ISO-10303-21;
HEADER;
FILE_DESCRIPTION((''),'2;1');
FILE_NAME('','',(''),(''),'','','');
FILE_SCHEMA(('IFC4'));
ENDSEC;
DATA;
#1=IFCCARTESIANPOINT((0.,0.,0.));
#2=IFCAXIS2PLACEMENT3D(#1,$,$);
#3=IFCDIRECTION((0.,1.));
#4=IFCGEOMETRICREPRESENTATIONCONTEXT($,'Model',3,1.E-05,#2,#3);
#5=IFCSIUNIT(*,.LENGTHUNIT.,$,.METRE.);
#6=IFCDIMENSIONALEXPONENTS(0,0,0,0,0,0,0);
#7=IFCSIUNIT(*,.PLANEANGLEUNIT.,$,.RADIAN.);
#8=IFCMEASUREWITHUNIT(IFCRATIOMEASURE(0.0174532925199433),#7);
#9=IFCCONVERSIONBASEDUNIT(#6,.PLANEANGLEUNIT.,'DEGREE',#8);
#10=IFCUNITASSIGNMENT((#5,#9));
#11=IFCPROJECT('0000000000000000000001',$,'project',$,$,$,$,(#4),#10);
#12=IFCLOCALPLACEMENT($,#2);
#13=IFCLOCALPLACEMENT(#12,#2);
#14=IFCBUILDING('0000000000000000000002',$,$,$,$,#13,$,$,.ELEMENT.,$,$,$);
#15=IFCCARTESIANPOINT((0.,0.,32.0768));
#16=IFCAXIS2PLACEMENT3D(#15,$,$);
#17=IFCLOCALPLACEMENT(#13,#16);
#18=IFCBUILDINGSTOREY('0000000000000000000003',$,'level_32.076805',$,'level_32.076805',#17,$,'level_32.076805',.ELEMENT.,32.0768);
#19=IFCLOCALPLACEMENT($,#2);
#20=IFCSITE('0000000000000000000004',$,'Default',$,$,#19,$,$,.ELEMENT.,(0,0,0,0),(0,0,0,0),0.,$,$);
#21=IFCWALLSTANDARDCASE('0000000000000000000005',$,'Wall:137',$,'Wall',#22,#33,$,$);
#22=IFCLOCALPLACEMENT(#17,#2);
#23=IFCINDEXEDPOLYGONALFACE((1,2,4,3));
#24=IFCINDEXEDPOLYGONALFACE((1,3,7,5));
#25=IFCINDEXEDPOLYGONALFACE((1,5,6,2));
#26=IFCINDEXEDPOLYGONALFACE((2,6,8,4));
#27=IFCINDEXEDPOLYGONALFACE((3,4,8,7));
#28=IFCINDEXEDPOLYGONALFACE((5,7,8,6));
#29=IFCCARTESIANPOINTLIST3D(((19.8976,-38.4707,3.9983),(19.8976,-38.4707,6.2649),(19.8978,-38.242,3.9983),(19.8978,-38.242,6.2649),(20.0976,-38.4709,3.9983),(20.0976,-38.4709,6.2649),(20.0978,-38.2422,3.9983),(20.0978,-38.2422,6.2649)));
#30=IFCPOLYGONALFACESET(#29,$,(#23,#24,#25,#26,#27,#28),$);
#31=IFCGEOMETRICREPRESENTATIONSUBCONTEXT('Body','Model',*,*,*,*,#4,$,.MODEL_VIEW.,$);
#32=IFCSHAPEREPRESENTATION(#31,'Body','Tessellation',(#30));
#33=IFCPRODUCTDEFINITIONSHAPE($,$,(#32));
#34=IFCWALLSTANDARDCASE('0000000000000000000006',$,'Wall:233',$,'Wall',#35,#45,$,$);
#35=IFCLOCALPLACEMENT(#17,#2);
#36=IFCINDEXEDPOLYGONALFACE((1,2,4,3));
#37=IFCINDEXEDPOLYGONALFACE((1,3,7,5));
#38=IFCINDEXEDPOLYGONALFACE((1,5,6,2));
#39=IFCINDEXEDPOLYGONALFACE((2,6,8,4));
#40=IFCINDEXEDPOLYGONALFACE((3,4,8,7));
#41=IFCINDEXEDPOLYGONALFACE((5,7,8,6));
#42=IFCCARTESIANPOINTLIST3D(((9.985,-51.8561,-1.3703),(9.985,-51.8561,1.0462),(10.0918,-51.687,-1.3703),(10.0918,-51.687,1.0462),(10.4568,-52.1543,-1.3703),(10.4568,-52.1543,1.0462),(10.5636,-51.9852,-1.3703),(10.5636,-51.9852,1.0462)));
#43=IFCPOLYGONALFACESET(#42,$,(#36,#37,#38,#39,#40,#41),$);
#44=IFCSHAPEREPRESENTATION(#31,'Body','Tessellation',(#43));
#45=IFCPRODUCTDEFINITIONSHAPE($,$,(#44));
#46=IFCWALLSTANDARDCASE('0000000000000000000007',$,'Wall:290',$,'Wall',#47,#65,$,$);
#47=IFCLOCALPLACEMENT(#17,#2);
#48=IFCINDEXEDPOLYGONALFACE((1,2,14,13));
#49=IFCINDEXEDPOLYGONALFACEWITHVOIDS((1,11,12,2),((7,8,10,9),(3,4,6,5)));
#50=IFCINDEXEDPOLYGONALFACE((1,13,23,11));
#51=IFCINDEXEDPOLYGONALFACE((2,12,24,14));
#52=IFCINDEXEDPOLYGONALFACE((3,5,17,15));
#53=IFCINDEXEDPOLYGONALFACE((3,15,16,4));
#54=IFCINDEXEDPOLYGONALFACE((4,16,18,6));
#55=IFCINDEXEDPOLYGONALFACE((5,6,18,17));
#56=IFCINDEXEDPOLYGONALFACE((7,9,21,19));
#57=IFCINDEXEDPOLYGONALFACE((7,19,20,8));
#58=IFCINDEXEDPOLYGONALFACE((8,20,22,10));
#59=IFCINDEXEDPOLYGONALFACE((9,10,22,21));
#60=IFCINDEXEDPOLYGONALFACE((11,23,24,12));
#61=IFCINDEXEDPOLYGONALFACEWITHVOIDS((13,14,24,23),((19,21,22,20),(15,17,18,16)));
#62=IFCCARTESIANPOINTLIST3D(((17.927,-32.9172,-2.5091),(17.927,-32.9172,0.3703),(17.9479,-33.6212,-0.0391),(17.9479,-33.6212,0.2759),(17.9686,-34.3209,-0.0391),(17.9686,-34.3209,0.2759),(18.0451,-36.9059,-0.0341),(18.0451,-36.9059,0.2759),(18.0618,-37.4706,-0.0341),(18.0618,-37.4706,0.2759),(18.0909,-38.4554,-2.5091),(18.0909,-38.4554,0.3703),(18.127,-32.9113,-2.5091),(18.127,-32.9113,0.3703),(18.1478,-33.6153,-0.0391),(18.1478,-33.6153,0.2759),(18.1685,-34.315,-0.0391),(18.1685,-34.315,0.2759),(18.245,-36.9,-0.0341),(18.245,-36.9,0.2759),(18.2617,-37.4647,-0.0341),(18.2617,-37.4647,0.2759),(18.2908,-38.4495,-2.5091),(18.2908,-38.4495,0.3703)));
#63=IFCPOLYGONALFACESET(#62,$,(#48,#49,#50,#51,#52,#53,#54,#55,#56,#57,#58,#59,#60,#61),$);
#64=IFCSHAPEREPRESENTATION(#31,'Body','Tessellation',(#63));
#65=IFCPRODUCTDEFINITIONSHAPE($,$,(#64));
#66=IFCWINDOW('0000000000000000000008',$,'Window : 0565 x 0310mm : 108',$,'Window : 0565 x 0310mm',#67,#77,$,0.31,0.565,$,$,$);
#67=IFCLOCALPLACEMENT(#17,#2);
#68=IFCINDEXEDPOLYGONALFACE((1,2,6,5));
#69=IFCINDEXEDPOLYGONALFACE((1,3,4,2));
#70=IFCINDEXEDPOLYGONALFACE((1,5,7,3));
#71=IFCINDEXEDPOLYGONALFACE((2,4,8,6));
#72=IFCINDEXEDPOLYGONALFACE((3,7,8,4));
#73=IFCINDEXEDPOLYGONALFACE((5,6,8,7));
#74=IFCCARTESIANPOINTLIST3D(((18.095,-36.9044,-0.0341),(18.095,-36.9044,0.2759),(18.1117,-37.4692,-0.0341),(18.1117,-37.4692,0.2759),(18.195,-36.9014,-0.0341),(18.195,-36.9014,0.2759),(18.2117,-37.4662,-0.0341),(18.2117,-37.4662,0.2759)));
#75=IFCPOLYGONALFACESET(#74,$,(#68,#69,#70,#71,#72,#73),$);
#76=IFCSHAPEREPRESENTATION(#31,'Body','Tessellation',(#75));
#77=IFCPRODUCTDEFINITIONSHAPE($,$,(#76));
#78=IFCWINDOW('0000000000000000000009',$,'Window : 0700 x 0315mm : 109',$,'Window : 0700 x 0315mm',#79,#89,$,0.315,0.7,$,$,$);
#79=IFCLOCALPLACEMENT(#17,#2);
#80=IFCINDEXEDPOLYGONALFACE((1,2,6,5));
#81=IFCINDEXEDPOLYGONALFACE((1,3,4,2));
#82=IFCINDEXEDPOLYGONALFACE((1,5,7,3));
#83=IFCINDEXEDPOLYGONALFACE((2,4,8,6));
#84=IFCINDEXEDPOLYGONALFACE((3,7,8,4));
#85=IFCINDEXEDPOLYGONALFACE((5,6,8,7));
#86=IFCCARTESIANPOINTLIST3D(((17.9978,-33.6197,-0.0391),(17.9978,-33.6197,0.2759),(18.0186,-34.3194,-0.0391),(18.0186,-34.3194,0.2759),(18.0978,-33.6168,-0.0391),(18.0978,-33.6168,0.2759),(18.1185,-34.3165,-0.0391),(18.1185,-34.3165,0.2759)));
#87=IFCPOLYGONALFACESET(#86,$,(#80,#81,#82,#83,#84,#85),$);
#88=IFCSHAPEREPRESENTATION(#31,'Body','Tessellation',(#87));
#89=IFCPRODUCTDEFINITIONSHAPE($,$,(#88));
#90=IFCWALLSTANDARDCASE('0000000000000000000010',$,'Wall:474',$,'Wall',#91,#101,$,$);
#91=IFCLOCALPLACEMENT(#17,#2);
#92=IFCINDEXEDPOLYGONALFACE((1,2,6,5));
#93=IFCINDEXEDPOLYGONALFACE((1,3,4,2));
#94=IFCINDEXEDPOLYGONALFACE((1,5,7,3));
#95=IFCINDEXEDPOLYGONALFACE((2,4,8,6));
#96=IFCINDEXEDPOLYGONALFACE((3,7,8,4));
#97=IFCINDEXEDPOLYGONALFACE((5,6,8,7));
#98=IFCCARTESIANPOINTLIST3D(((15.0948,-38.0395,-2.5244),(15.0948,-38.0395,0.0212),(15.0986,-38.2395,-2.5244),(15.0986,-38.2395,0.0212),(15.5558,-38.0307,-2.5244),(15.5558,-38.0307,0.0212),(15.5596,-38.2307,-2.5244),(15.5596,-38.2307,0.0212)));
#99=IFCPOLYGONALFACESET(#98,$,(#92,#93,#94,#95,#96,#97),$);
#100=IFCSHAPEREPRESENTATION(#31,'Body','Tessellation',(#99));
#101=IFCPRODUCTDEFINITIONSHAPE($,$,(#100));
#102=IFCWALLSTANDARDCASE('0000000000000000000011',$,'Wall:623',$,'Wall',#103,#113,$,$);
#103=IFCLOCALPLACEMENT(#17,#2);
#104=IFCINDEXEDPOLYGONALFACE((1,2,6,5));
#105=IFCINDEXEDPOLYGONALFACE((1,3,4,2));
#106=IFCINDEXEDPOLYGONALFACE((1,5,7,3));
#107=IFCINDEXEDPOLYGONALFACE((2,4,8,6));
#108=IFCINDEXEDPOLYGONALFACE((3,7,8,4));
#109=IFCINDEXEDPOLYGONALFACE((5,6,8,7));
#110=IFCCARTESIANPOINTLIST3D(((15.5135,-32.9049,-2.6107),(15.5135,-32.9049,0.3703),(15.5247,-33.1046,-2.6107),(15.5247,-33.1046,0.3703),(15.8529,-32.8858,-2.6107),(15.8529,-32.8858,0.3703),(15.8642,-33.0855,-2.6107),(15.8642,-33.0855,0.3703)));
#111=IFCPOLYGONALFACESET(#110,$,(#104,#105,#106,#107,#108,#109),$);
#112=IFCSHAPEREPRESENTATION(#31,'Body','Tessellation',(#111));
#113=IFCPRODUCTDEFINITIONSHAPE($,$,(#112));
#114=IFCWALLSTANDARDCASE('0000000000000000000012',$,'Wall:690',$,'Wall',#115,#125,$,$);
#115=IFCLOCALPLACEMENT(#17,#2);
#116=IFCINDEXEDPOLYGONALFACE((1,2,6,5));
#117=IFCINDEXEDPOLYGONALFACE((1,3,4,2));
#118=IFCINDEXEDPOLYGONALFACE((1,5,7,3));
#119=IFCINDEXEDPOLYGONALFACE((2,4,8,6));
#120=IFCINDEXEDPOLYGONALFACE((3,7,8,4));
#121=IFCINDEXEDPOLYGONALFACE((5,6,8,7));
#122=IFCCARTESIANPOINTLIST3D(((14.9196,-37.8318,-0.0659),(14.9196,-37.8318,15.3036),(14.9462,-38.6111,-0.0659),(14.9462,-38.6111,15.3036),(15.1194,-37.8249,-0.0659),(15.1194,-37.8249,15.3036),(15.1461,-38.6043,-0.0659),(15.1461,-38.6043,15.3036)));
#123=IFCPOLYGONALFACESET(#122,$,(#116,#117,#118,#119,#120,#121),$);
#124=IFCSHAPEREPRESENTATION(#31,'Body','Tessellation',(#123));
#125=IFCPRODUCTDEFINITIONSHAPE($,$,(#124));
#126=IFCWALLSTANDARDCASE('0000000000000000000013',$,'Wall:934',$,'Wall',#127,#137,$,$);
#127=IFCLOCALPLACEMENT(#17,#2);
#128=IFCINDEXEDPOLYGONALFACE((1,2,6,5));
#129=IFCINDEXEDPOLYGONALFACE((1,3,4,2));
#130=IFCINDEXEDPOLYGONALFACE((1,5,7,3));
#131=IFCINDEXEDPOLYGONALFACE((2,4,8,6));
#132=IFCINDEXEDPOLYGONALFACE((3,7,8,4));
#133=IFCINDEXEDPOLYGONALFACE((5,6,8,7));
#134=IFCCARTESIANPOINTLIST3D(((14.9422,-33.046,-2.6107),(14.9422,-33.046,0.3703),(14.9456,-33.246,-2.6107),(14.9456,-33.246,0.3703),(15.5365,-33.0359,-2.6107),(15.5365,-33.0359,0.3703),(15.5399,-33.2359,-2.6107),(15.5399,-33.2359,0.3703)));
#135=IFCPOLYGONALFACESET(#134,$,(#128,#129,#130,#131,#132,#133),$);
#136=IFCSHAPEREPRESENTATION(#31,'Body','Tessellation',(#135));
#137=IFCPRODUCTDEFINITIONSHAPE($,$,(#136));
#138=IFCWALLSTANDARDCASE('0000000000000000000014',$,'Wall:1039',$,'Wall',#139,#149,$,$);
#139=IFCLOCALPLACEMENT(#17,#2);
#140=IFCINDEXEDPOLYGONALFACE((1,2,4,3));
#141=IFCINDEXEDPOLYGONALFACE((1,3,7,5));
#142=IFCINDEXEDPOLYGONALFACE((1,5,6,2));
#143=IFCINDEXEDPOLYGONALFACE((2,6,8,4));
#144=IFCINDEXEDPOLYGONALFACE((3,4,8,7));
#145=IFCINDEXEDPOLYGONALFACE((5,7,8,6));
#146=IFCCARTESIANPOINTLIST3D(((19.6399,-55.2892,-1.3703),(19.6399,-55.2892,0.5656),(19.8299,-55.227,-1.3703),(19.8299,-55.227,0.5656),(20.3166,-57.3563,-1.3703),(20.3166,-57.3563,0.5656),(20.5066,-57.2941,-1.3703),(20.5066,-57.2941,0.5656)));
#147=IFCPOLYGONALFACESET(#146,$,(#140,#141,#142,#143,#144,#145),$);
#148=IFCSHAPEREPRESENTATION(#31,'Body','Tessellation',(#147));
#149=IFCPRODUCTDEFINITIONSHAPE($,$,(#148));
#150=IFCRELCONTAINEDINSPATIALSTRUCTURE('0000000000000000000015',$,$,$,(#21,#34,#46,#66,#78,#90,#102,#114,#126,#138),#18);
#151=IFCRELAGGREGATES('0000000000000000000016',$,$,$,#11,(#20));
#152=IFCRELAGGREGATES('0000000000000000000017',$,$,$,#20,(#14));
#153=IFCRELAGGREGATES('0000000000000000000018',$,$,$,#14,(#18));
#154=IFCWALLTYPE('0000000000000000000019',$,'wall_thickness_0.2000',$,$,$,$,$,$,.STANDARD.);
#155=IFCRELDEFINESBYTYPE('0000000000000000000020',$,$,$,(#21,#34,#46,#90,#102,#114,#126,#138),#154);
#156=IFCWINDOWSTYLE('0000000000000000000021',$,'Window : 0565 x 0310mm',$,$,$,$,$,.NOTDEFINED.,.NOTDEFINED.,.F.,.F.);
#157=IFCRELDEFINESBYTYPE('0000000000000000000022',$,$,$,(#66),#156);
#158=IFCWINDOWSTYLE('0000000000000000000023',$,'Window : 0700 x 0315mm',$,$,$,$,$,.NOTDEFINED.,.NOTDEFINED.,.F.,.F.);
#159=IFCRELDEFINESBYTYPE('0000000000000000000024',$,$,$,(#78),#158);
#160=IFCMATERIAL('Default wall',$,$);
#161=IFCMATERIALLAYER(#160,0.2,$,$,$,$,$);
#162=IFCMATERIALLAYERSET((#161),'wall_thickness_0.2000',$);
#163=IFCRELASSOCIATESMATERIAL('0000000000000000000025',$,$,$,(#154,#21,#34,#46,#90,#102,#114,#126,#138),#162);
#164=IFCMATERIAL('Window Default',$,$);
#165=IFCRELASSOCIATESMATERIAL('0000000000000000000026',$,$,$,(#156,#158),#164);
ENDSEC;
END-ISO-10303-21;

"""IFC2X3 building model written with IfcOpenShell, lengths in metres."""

from ifc_helpers import new_model, entity, si_unit, converted_unit, direction, frame, frame_2d, origin, origin_2d_with_axis, place, context, subcontext, project, spatial, polyline, rectangle, outline, extrude, source, transform, mapped, material, layer, layer_set, layer_usage, type_object, type_shapes, element, fill, save


model = new_model("IFC2X3")

# Units and contexts
model_context = context("Model", 3, precision=1e-05, world=origin(), true_north=direction((0.0, 1.0)))
body_context = subcontext(model_context, "Body", "Model", "MODEL_VIEW")
ifc_project = project(units=[si_unit("LENGTHUNIT", "METRE"), converted_unit("PLANEANGLEUNIT", "DEGREE", entity("IfcRatioMeasure", 0.0174532925199433), si_unit("PLANEANGLEUNIT", "RADIAN"), dimensions=[0, 0, 0, 0, 0, 0, 0])], contexts=[model_context])

# Site, building, storey
site_placement = place(None, origin())
site = spatial("IfcSite", under=ifc_project, at=site_placement, Name="Default", CompositionType="ELEMENT", RefLatitude=(0, 0, 0, 0), RefLongitude=(0, 0, 0, 0), RefElevation=0.0)
placement_1 = place(None, origin())
building_placement = place(placement_1, origin())
building = spatial("IfcBuilding", under=site, at=building_placement, CompositionType="ELEMENT")
storey_placement = place(building_placement, frame((0.0, 0.0, 32.0768)))
storey = spatial("IfcBuildingStorey", under=building, at=storey_placement, Name="level_32.076805", ObjectType="level_32.076805", LongName="level_32.076805", CompositionType="ELEMENT", Elevation=32.0768)

# Walls
ifc_material_1 = material(Name="Default wall")
ifc_layer = layer(ifc_material_1, 0.2)
ifc_layer_set = layer_set([ifc_layer], Name="wall_thickness_0.2000")
ifc_layer_usage = layer_usage(ifc_layer_set, "AXIS2", "POSITIVE", -0.1)
wall_type = type_object("IfcWallType", Name="wall_thickness_0.2000", PredefinedType="STANDARD", material=ifc_layer_set)
placement_2 = place(building_placement, frame((0.0, 0.0, 36.0751)))
wall_1_placement = place(placement_2, frame((19.9976, -38.4708, 0.0), z_axis=(0.0, 0.0, 1.0), x_axis=(0.001093, 0.999999, 0.0)))
element("IfcWallStandardCase", 1, at=wall_1_placement, inside=storey, type_object=wall_type, material=ifc_layer_usage, Name="Wall:137", ObjectType="Wall", context=body_context, shape_type="SweptSolid", body=[
    extrude(outline(polyline([(0.2287, -0.1), (0.2287, 0.1), (0.0, 0.1), (0.0, -0.1), (0.2287, -0.1)])), origin(), (0.0, 0.0, 1.0), 2.2666),
])
placement_3 = place(building_placement, frame((0.0, 0.0, 30.7065)))
wall_2_placement = place(placement_3, frame((10.5102, -52.0698, 0.0), z_axis=(0.0, 0.0, 1.0), x_axis=(-0.84531, 0.534276, 0.0)))
element("IfcWallStandardCase", 2, at=wall_2_placement, inside=storey, type_object=wall_type, material=ifc_layer_usage, Name="Wall:233", ObjectType="Wall", context=body_context, shape_type="SweptSolid", body=[
    extrude(outline(polyline([(0.5581, -0.1), (0.5581, 0.1), (0.0, 0.1), (0.0, -0.1), (0.5581, -0.1)])), origin(), (0.0, 0.0, 1.0), 2.4165),
])

# Wall, openings, windows
placement_4 = place(building_placement, frame((0.0, 0.0, 29.5677)))
wall_3_placement = place(placement_4, frame((18.1909, -38.4525, 0.0), z_axis=(0.0, 0.0, 1.0), x_axis=(-0.029576, 0.999563, 0.0)))
wall_3 = element("IfcWallStandardCase", 3, at=wall_3_placement, inside=storey, type_object=wall_type, material=ifc_layer_usage, Name="Wall:290", ObjectType="Wall", context=body_context, shape_type="SweptSolid", body=[
    extrude(outline(polyline([(5.5406, -0.1), (5.5406, 0.1), (0.0, 0.1), (0.0, -0.1), (5.5406, -0.1)])), origin(), (0.0, 0.0, 1.0), 2.8794),
])
opening_1_placement = place(wall_3_placement, frame((0.9852, -0.1, 2.475)))
opening_1 = element("IfcOpeningElement", 4, at=opening_1_placement, cuts=wall_3, ObjectType="Opening", context=body_context, shape_type="SweptSolid", body=[
    extrude(rectangle(XDim=0.565, YDim=0.31, at=frame_2d((0.155, 0.2825), x_axis=(0.0, 1.0))), frame((0.0, 0.0, 0.0), z_axis=(0.0, 1.0, 0.0), x_axis=(0.0, 0.0, 1.0)), (0.0, 0.0, 1.0), 0.2),
])
opening_2_placement = place(wall_3_placement, frame((4.1363, -0.1, 2.47)))
opening_2 = element("IfcOpeningElement", 5, at=opening_2_placement, cuts=wall_3, ObjectType="Opening", context=body_context, shape_type="SweptSolid", body=[
    extrude(rectangle(XDim=0.7, YDim=0.315, at=frame_2d((0.1575, 0.35), x_axis=(0.0, 1.0))), frame((0.0, 0.0, 0.0), z_axis=(0.0, 1.0, 0.0), x_axis=(0.0, 0.0, 1.0)), (0.0, 0.0, 1.0), 0.2),
])
ifc_material_2 = material(Name="Window Default")
window_style_1 = type_object("IfcWindowStyle", Name="Window : 0565 x 0310mm", ConstructionType="NOTDEFINED", OperationType="NOTDEFINED", ParameterTakesPrecedence=False, Sizeable=False, material=ifc_material_2)
shared_shape_1 = source(origin(), body_context, "Body", "SweptSolid", [
    extrude(rectangle(XDim=0.1, YDim=0.565, at=origin_2d_with_axis()), frame((0.2825, 0.1, 0.0), z_axis=(0.0, 0.0, 1.0), x_axis=(0.0, 1.0, 0.0)), (0.0, 0.0, 1.0), 0.31),
])
type_shapes(window_style_1, [shared_shape_1])
window_1_placement = place(opening_1_placement, origin())
window_1 = element("IfcWindow", 6, at=window_1_placement, inside=storey, type_object=window_style_1, Name="Window : 0565 x 0310mm : 108", ObjectType="Window : 0565 x 0310mm", OverallHeight=0.31, OverallWidth=0.565, context=body_context, shape_type="MappedRepresentation", body=[
    mapped(shared_shape_1, transform((0.0, 0.0, 0.0), scale=1.0)),
])
fill(opening_1, window_1)
window_style_2 = type_object("IfcWindowStyle", Name="Window : 0700 x 0315mm", ConstructionType="NOTDEFINED", OperationType="NOTDEFINED", ParameterTakesPrecedence=False, Sizeable=False, material=ifc_material_2)
shared_shape_2 = source(origin(), body_context, "Body", "SweptSolid", [
    extrude(rectangle(XDim=0.1, YDim=0.7, at=origin_2d_with_axis()), frame((0.35, 0.1, 0.0), z_axis=(0.0, 0.0, 1.0), x_axis=(0.0, 1.0, 0.0)), (0.0, 0.0, 1.0), 0.315),
])
type_shapes(window_style_2, [shared_shape_2])
window_2_placement = place(opening_2_placement, origin())
window_2 = element("IfcWindow", 7, at=window_2_placement, inside=storey, type_object=window_style_2, Name="Window : 0700 x 0315mm : 109", ObjectType="Window : 0700 x 0315mm", OverallHeight=0.315, OverallWidth=0.7, context=body_context, shape_type="MappedRepresentation", body=[
    mapped(shared_shape_2, transform((0.0, 0.0, 0.0), scale=1.0)),
])
fill(opening_2, window_2)

# Walls
placement_5 = place(building_placement, frame((0.0, 0.0, 29.5524)))
wall_4_placement = place(placement_5, frame((15.5577, -38.1307, 0.0), z_axis=(0.0, 0.0, 1.0), x_axis=(-0.999819, -0.019046, 0.0)))
element("IfcWallStandardCase", 8, at=wall_4_placement, inside=storey, type_object=wall_type, material=ifc_layer_usage, Name="Wall:474", ObjectType="Wall", context=body_context, shape_type="SweptSolid", body=[
    extrude(outline(polyline([(0.4611, -0.1), (0.4611, 0.1), (0.0, 0.1), (0.0, -0.1), (0.4611, -0.1)])), origin(), (0.0, 0.0, 1.0), 2.5456),
])
placement_6 = place(building_placement, frame((0.0, 0.0, 29.4661)))
wall_5_placement = place(placement_6, frame((15.8585, -32.9856, 0.0), z_axis=(0.0, 0.0, 1.0), x_axis=(-0.998418, -0.056233, 0.0)))
element("IfcWallStandardCase", 9, at=wall_5_placement, inside=storey, type_object=wall_type, material=ifc_layer_usage, Name="Wall:623", ObjectType="Wall", context=body_context, shape_type="SweptSolid", body=[
    extrude(outline(polyline([(0.34, -0.1), (0.34, 0.1), (0.0, 0.1), (0.0, -0.1), (0.34, -0.1)])), origin(), (0.0, 0.0, 1.0), 2.981),
])
placement_7 = place(building_placement, frame((0.0, 0.0, 32.0109)))
wall_6_placement = place(placement_7, frame((15.0461, -38.6077, 0.0), z_axis=(0.0, 0.0, 1.0), x_axis=(-0.034129, 0.999417, 0.0)))
element("IfcWallStandardCase", 10, at=wall_6_placement, inside=storey, type_object=wall_type, material=ifc_layer_usage, Name="Wall:690", ObjectType="Wall", context=body_context, shape_type="SweptSolid", body=[
    extrude(outline(polyline([(0.7798, -0.1), (0.7798, 0.1), (0.0, 0.1), (0.0, -0.1), (0.7798, -0.1)])), origin(), (0.0, 0.0, 1.0), 15.3695),
])
placement_8 = place(building_placement, frame((0.0, 0.0, 29.4661)))
wall_7_placement = place(placement_8, frame((15.5382, -33.1359, 0.0), z_axis=(0.0, 0.0, 1.0), x_axis=(-0.999857, -0.016886, 0.0)))
element("IfcWallStandardCase", 11, at=wall_7_placement, inside=storey, type_object=wall_type, material=ifc_layer_usage, Name="Wall:934", ObjectType="Wall", context=body_context, shape_type="SweptSolid", body=[
    extrude(outline(polyline([(0.5944, -0.1), (0.5944, 0.1), (0.0, 0.1), (0.0, -0.1), (0.5944, -0.1)])), origin(), (0.0, 0.0, 1.0), 2.981),
])
placement_9 = place(building_placement, frame((0.0, 0.0, 30.7065)))
wall_8_placement = place(placement_9, frame((20.4116, -57.3252, 0.0), z_axis=(0.0, 0.0, 1.0), x_axis=(-0.311121, 0.95037, 0.0)))
element("IfcWallStandardCase", 12, at=wall_8_placement, inside=storey, type_object=wall_type, material=ifc_layer_usage, Name="Wall:1039", ObjectType="Wall", context=body_context, shape_type="SweptSolid", body=[
    extrude(outline(polyline([(2.175, -0.1), (2.175, 0.1), (0.0, 0.1), (0.0, -0.1), (2.175, -0.1)])), origin(), (0.0, 0.0, 1.0), 1.9359),
])

save(model, "model.ifc")
